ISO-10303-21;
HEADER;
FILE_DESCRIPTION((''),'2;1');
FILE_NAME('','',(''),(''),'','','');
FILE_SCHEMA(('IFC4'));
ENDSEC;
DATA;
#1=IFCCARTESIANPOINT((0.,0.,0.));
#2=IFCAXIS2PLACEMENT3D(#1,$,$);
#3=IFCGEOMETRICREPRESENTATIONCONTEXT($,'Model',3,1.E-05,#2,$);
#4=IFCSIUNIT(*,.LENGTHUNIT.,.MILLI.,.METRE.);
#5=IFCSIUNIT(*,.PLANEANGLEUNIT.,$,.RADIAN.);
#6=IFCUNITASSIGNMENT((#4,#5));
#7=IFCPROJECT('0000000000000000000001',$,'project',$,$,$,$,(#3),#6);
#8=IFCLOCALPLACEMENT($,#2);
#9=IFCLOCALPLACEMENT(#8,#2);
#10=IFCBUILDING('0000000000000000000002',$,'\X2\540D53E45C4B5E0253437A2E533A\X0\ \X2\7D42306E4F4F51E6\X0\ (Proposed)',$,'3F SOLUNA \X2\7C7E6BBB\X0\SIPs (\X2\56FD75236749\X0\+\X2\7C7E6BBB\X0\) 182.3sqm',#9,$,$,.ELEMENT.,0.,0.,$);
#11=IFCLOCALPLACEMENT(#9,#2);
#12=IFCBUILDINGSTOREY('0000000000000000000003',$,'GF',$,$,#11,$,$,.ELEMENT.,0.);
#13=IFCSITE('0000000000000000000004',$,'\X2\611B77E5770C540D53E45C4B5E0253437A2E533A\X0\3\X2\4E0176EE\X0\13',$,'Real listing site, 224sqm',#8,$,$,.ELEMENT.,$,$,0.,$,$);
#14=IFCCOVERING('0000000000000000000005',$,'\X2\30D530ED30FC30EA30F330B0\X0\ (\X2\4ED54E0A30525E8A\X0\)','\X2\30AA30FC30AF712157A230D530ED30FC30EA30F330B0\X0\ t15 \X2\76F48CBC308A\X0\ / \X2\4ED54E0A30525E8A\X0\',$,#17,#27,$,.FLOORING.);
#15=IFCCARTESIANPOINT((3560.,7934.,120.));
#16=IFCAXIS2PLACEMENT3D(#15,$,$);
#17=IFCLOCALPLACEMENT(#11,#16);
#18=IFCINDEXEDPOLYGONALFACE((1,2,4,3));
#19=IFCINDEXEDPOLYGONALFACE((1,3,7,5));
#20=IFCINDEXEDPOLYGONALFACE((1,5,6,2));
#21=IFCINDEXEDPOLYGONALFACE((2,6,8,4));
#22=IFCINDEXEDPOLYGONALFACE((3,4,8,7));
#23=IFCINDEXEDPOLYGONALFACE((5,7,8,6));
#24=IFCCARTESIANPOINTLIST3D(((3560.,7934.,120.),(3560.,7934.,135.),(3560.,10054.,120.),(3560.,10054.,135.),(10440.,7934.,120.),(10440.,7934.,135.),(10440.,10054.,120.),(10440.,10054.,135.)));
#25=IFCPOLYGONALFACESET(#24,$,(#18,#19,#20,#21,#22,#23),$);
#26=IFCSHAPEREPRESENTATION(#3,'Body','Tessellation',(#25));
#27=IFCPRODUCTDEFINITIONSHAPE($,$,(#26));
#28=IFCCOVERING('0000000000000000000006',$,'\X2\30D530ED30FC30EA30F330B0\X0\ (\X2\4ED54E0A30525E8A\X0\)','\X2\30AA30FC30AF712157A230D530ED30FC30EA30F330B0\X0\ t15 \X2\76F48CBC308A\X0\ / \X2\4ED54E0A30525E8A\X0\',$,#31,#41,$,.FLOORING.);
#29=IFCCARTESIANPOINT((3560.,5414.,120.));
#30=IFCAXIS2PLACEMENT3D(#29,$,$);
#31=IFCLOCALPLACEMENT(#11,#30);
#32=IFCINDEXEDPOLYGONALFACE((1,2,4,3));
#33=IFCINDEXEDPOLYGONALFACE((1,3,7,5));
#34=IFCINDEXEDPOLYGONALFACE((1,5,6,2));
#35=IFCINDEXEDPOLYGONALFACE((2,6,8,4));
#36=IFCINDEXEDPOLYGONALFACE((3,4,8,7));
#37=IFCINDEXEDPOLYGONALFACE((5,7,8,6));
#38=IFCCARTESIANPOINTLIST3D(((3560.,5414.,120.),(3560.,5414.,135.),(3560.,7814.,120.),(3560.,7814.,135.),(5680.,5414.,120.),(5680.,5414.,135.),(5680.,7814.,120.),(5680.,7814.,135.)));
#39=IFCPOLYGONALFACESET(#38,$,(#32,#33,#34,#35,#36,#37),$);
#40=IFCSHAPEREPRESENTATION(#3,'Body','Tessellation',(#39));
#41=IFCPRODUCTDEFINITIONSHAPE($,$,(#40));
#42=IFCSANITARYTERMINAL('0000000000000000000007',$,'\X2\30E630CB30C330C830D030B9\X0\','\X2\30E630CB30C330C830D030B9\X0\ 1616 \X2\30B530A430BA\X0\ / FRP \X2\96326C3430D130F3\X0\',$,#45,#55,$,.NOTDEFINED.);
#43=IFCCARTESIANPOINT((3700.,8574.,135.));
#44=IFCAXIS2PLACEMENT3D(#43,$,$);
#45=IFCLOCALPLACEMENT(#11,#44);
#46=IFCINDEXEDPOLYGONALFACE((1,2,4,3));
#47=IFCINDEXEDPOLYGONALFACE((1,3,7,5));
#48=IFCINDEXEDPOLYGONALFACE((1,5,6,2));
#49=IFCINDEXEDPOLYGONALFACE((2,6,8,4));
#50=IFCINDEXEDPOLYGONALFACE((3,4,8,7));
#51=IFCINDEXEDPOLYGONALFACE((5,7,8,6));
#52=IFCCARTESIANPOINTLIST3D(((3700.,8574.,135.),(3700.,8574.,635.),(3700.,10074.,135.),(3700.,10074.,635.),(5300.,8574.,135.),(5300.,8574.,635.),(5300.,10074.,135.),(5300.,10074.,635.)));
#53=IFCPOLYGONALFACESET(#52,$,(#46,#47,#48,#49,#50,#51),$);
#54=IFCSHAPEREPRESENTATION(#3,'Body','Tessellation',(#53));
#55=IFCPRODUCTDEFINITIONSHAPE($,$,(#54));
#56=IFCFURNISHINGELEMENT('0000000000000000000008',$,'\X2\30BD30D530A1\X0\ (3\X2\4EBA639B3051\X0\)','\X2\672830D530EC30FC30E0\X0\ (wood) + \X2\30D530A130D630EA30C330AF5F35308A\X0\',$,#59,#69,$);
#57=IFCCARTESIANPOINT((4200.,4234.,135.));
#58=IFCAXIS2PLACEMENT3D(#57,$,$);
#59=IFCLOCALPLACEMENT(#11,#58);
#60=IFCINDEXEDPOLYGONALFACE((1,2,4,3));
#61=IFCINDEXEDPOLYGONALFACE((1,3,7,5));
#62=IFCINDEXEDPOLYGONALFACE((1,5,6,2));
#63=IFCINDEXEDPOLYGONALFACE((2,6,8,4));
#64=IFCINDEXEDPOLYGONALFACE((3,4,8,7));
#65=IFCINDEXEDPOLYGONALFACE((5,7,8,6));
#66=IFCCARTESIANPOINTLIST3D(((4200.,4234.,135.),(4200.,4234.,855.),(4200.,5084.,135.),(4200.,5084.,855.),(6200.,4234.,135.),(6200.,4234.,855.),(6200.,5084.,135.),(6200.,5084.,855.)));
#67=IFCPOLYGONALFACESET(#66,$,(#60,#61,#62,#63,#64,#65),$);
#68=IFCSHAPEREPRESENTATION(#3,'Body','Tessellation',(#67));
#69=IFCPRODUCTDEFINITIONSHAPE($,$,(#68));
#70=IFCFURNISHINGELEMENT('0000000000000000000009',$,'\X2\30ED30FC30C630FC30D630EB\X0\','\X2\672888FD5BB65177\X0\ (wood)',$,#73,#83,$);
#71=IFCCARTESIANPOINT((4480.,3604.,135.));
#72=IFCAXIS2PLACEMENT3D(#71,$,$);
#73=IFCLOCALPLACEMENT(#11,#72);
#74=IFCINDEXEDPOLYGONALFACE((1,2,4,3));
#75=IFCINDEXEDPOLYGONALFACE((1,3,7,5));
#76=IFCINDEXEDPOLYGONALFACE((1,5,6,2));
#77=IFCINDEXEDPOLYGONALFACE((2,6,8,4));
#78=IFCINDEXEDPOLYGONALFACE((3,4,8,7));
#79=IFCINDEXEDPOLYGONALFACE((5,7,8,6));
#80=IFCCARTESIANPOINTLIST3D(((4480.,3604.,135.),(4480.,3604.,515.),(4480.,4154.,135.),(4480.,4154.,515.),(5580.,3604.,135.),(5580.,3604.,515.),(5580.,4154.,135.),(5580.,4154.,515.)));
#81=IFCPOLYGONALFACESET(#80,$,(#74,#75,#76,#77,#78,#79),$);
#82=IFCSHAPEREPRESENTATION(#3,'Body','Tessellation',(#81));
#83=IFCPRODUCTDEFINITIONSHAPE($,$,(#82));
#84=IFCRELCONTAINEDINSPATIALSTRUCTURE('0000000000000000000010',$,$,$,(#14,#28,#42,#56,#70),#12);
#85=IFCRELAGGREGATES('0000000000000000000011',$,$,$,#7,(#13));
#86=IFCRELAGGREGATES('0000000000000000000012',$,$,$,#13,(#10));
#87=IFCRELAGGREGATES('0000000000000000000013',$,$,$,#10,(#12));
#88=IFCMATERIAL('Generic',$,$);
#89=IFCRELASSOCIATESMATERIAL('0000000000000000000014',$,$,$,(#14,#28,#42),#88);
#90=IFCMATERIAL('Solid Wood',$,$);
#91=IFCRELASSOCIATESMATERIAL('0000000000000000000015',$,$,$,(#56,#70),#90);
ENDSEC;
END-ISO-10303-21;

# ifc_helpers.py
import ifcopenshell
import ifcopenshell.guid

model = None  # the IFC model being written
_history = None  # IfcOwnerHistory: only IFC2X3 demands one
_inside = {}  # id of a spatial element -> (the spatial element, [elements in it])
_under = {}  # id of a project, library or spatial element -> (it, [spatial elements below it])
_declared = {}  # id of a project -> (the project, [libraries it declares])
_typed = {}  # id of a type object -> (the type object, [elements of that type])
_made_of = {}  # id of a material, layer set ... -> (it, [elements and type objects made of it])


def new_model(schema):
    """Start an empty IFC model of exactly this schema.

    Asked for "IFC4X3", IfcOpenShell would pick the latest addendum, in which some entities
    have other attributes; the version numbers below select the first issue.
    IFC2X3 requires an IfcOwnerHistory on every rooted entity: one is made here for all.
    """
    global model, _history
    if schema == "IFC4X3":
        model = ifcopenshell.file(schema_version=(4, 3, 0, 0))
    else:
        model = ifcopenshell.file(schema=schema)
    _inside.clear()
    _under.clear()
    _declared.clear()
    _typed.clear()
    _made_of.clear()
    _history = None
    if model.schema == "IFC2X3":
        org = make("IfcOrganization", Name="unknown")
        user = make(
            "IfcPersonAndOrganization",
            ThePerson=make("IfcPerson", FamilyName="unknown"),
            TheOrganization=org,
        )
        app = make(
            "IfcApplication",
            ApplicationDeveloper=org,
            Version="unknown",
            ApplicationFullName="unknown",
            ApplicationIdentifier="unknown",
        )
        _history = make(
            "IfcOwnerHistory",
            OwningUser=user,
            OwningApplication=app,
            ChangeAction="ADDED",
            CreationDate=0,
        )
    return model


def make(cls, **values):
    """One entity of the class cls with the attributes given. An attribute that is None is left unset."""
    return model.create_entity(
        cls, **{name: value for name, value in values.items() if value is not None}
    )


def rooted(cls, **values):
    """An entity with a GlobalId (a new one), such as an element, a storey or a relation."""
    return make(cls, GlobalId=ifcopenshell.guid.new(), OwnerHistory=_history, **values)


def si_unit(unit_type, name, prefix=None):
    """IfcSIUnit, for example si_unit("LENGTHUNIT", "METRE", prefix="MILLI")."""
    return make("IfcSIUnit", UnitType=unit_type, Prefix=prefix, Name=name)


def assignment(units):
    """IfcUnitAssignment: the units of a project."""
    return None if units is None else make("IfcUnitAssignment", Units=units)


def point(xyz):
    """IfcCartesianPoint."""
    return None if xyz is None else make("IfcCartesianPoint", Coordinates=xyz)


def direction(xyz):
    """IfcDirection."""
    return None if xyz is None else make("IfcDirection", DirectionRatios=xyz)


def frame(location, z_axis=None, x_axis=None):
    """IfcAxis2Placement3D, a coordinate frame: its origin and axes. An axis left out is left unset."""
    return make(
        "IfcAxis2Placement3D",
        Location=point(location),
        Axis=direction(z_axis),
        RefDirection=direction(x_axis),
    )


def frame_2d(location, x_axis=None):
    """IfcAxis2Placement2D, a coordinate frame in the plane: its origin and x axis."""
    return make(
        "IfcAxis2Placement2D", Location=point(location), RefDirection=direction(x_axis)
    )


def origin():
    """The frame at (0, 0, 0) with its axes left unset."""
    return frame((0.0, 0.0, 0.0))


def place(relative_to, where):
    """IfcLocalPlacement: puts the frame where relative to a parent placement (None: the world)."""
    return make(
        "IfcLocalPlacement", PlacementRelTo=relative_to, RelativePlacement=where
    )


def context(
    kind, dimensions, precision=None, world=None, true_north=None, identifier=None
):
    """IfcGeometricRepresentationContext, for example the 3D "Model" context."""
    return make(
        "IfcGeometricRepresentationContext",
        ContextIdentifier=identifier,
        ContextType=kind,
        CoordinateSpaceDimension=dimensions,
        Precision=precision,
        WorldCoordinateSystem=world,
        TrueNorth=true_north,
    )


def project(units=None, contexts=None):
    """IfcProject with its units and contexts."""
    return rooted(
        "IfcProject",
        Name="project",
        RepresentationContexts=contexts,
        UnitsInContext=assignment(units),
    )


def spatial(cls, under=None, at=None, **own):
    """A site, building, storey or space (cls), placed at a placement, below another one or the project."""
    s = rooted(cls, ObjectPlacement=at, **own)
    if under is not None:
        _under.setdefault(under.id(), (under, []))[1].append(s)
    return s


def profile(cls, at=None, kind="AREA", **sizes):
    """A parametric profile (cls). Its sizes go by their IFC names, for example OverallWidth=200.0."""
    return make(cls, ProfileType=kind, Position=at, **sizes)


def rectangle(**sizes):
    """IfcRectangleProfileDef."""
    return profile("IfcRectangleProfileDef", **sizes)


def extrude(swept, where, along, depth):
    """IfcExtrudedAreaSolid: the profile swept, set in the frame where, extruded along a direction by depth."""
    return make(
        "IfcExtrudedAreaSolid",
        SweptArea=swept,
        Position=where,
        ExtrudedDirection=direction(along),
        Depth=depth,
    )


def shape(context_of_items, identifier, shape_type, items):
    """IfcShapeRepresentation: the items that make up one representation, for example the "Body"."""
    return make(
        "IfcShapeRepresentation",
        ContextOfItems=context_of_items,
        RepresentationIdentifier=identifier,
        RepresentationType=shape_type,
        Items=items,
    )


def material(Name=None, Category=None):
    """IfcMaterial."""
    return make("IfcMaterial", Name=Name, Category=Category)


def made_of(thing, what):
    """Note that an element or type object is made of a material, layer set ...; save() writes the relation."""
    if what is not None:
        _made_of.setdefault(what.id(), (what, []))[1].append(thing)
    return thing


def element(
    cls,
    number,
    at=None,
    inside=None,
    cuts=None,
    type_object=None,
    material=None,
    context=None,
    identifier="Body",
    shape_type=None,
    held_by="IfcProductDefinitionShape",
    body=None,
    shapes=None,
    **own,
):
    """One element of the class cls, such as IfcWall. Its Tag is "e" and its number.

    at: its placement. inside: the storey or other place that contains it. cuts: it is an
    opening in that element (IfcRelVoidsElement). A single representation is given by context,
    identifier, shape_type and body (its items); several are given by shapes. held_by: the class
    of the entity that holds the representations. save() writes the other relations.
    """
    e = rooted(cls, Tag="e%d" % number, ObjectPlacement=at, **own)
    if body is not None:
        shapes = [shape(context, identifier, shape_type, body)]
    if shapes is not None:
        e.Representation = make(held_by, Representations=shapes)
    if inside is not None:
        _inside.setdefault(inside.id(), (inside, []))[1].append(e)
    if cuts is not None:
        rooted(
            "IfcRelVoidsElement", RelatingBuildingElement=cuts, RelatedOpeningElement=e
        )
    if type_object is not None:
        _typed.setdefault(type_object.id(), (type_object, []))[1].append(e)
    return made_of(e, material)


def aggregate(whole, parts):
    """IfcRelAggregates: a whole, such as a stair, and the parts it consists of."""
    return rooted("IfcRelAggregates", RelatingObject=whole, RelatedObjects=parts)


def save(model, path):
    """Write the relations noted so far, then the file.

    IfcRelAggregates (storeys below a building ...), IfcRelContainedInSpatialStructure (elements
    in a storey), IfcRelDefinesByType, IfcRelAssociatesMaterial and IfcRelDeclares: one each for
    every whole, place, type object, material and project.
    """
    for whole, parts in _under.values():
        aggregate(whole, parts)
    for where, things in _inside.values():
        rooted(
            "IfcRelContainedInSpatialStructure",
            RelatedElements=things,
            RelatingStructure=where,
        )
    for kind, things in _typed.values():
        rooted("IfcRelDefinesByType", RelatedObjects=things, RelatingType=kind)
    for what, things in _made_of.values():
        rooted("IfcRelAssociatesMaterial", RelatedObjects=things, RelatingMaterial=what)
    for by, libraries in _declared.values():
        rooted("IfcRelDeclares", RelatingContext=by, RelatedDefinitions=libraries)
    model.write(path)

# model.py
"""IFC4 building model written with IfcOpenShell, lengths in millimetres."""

from ifc_helpers import new_model, si_unit, frame, frame_2d, origin, place, context, project, spatial, rectangle, extrude, material, element, save


model = new_model("IFC4")

# Units and contexts
model_context = context("Model", 3, precision=1e-05, world=origin())
ifc_project = project(units=[si_unit("LENGTHUNIT", "METRE", prefix="MILLI"), si_unit("PLANEANGLEUNIT", "RADIAN")], contexts=[model_context])

# Site, building, storey
site_placement = place(None, origin())
site = spatial("IfcSite", under=ifc_project, at=site_placement, Name="愛知県名古屋市千種区3丁目13", ObjectType="Real listing site, 224sqm", CompositionType="ELEMENT", RefElevation=0.0)
building_placement = place(site_placement, origin())
building = spatial("IfcBuilding", under=site, at=building_placement, Name="名古屋市千種区 終の住処 (Proposed)", ObjectType="3F SOLUNA 籾殻SIPs (国産杉+籾殻) 182.3sqm", CompositionType="ELEMENT", ElevationOfRefHeight=0.0, ElevationOfTerrain=0.0)
storey_placement = place(building_placement, origin())
storey = spatial("IfcBuildingStorey", under=building, at=storey_placement, Name="GF", CompositionType="ELEMENT", Elevation=0.0)

# Shared definitions
ifc_material_1 = material(Name="Solid Wood")

# Coverings
ifc_material_2 = material(Name="Generic")
covering_1_placement = place(storey_placement, frame((3560.0, 7934.0, 120.0)))
element("IfcCovering", 1, at=covering_1_placement, inside=storey, material=ifc_material_2, Name="フローリング (仕上げ床)", Description="オーク無垢フローリング t15 直貼り / 仕上げ床", PredefinedType="FLOORING", context=model_context, shape_type="SweptSolid", body=[
    extrude(rectangle(XDim=6880.0, YDim=2120.0, at=frame_2d((3440.0, 1060.0))), frame((3560.0, 7934.0, 120.0)), (0.0, 0.0, 1.0), 15.0),
])
covering_2_placement = place(storey_placement, frame((3560.0, 5414.0, 120.0)))
element("IfcCovering", 2, at=covering_2_placement, inside=storey, material=ifc_material_2, Name="フローリング (仕上げ床)", Description="オーク無垢フローリング t15 直貼り / 仕上げ床", PredefinedType="FLOORING", context=model_context, shape_type="SweptSolid", body=[
    extrude(rectangle(XDim=2120.0, YDim=2400.0, at=frame_2d((1060.0, 1200.0))), frame((3560.0, 5414.0, 120.0)), (0.0, 0.0, 1.0), 15.0),
])

# Sanitary terminal
sanitary_terminal_placement = place(storey_placement, frame((3700.0, 8574.0, 135.0)))
element("IfcSanitaryTerminal", 3, at=sanitary_terminal_placement, inside=storey, material=ifc_material_2, Name="ユニットバス", Description="ユニットバス 1616 サイズ / FRP 防水パン", PredefinedType="NOTDEFINED", context=model_context, shape_type="SweptSolid", body=[
    extrude(rectangle(XDim=1600.0, YDim=1500.0, at=frame_2d((800.0, 750.0))), frame((3700.0, 8574.0, 135.0)), (0.0, 0.0, 1.0), 500.0),
])

# Furnishing elements
furnishing_1_placement = place(storey_placement, frame((4200.0, 4234.0, 135.0)))
element("IfcFurnishingElement", 4, at=furnishing_1_placement, inside=storey, material=ifc_material_1, Name="ソファ (3人掛け)", Description="木フレーム (wood) + ファブリック張り", context=model_context, shape_type="SweptSolid", body=[
    extrude(rectangle(XDim=2000.0, YDim=850.0, at=frame_2d((1000.0, 425.0))), frame((4200.0, 4234.0, 135.0)), (0.0, 0.0, 1.0), 720.0),
])
furnishing_2_placement = place(storey_placement, frame((4480.0, 3604.0, 135.0)))
element("IfcFurnishingElement", 5, at=furnishing_2_placement, inside=storey, material=ifc_material_1, Name="ローテーブル", Description="木製家具 (wood)", context=model_context, shape_type="SweptSolid", body=[
    extrude(rectangle(XDim=1100.0, YDim=550.0, at=frame_2d((550.0, 275.0))), frame((4480.0, 3604.0, 135.0)), (0.0, 0.0, 1.0), 380.0),
])

save(model, "model.ifc")
